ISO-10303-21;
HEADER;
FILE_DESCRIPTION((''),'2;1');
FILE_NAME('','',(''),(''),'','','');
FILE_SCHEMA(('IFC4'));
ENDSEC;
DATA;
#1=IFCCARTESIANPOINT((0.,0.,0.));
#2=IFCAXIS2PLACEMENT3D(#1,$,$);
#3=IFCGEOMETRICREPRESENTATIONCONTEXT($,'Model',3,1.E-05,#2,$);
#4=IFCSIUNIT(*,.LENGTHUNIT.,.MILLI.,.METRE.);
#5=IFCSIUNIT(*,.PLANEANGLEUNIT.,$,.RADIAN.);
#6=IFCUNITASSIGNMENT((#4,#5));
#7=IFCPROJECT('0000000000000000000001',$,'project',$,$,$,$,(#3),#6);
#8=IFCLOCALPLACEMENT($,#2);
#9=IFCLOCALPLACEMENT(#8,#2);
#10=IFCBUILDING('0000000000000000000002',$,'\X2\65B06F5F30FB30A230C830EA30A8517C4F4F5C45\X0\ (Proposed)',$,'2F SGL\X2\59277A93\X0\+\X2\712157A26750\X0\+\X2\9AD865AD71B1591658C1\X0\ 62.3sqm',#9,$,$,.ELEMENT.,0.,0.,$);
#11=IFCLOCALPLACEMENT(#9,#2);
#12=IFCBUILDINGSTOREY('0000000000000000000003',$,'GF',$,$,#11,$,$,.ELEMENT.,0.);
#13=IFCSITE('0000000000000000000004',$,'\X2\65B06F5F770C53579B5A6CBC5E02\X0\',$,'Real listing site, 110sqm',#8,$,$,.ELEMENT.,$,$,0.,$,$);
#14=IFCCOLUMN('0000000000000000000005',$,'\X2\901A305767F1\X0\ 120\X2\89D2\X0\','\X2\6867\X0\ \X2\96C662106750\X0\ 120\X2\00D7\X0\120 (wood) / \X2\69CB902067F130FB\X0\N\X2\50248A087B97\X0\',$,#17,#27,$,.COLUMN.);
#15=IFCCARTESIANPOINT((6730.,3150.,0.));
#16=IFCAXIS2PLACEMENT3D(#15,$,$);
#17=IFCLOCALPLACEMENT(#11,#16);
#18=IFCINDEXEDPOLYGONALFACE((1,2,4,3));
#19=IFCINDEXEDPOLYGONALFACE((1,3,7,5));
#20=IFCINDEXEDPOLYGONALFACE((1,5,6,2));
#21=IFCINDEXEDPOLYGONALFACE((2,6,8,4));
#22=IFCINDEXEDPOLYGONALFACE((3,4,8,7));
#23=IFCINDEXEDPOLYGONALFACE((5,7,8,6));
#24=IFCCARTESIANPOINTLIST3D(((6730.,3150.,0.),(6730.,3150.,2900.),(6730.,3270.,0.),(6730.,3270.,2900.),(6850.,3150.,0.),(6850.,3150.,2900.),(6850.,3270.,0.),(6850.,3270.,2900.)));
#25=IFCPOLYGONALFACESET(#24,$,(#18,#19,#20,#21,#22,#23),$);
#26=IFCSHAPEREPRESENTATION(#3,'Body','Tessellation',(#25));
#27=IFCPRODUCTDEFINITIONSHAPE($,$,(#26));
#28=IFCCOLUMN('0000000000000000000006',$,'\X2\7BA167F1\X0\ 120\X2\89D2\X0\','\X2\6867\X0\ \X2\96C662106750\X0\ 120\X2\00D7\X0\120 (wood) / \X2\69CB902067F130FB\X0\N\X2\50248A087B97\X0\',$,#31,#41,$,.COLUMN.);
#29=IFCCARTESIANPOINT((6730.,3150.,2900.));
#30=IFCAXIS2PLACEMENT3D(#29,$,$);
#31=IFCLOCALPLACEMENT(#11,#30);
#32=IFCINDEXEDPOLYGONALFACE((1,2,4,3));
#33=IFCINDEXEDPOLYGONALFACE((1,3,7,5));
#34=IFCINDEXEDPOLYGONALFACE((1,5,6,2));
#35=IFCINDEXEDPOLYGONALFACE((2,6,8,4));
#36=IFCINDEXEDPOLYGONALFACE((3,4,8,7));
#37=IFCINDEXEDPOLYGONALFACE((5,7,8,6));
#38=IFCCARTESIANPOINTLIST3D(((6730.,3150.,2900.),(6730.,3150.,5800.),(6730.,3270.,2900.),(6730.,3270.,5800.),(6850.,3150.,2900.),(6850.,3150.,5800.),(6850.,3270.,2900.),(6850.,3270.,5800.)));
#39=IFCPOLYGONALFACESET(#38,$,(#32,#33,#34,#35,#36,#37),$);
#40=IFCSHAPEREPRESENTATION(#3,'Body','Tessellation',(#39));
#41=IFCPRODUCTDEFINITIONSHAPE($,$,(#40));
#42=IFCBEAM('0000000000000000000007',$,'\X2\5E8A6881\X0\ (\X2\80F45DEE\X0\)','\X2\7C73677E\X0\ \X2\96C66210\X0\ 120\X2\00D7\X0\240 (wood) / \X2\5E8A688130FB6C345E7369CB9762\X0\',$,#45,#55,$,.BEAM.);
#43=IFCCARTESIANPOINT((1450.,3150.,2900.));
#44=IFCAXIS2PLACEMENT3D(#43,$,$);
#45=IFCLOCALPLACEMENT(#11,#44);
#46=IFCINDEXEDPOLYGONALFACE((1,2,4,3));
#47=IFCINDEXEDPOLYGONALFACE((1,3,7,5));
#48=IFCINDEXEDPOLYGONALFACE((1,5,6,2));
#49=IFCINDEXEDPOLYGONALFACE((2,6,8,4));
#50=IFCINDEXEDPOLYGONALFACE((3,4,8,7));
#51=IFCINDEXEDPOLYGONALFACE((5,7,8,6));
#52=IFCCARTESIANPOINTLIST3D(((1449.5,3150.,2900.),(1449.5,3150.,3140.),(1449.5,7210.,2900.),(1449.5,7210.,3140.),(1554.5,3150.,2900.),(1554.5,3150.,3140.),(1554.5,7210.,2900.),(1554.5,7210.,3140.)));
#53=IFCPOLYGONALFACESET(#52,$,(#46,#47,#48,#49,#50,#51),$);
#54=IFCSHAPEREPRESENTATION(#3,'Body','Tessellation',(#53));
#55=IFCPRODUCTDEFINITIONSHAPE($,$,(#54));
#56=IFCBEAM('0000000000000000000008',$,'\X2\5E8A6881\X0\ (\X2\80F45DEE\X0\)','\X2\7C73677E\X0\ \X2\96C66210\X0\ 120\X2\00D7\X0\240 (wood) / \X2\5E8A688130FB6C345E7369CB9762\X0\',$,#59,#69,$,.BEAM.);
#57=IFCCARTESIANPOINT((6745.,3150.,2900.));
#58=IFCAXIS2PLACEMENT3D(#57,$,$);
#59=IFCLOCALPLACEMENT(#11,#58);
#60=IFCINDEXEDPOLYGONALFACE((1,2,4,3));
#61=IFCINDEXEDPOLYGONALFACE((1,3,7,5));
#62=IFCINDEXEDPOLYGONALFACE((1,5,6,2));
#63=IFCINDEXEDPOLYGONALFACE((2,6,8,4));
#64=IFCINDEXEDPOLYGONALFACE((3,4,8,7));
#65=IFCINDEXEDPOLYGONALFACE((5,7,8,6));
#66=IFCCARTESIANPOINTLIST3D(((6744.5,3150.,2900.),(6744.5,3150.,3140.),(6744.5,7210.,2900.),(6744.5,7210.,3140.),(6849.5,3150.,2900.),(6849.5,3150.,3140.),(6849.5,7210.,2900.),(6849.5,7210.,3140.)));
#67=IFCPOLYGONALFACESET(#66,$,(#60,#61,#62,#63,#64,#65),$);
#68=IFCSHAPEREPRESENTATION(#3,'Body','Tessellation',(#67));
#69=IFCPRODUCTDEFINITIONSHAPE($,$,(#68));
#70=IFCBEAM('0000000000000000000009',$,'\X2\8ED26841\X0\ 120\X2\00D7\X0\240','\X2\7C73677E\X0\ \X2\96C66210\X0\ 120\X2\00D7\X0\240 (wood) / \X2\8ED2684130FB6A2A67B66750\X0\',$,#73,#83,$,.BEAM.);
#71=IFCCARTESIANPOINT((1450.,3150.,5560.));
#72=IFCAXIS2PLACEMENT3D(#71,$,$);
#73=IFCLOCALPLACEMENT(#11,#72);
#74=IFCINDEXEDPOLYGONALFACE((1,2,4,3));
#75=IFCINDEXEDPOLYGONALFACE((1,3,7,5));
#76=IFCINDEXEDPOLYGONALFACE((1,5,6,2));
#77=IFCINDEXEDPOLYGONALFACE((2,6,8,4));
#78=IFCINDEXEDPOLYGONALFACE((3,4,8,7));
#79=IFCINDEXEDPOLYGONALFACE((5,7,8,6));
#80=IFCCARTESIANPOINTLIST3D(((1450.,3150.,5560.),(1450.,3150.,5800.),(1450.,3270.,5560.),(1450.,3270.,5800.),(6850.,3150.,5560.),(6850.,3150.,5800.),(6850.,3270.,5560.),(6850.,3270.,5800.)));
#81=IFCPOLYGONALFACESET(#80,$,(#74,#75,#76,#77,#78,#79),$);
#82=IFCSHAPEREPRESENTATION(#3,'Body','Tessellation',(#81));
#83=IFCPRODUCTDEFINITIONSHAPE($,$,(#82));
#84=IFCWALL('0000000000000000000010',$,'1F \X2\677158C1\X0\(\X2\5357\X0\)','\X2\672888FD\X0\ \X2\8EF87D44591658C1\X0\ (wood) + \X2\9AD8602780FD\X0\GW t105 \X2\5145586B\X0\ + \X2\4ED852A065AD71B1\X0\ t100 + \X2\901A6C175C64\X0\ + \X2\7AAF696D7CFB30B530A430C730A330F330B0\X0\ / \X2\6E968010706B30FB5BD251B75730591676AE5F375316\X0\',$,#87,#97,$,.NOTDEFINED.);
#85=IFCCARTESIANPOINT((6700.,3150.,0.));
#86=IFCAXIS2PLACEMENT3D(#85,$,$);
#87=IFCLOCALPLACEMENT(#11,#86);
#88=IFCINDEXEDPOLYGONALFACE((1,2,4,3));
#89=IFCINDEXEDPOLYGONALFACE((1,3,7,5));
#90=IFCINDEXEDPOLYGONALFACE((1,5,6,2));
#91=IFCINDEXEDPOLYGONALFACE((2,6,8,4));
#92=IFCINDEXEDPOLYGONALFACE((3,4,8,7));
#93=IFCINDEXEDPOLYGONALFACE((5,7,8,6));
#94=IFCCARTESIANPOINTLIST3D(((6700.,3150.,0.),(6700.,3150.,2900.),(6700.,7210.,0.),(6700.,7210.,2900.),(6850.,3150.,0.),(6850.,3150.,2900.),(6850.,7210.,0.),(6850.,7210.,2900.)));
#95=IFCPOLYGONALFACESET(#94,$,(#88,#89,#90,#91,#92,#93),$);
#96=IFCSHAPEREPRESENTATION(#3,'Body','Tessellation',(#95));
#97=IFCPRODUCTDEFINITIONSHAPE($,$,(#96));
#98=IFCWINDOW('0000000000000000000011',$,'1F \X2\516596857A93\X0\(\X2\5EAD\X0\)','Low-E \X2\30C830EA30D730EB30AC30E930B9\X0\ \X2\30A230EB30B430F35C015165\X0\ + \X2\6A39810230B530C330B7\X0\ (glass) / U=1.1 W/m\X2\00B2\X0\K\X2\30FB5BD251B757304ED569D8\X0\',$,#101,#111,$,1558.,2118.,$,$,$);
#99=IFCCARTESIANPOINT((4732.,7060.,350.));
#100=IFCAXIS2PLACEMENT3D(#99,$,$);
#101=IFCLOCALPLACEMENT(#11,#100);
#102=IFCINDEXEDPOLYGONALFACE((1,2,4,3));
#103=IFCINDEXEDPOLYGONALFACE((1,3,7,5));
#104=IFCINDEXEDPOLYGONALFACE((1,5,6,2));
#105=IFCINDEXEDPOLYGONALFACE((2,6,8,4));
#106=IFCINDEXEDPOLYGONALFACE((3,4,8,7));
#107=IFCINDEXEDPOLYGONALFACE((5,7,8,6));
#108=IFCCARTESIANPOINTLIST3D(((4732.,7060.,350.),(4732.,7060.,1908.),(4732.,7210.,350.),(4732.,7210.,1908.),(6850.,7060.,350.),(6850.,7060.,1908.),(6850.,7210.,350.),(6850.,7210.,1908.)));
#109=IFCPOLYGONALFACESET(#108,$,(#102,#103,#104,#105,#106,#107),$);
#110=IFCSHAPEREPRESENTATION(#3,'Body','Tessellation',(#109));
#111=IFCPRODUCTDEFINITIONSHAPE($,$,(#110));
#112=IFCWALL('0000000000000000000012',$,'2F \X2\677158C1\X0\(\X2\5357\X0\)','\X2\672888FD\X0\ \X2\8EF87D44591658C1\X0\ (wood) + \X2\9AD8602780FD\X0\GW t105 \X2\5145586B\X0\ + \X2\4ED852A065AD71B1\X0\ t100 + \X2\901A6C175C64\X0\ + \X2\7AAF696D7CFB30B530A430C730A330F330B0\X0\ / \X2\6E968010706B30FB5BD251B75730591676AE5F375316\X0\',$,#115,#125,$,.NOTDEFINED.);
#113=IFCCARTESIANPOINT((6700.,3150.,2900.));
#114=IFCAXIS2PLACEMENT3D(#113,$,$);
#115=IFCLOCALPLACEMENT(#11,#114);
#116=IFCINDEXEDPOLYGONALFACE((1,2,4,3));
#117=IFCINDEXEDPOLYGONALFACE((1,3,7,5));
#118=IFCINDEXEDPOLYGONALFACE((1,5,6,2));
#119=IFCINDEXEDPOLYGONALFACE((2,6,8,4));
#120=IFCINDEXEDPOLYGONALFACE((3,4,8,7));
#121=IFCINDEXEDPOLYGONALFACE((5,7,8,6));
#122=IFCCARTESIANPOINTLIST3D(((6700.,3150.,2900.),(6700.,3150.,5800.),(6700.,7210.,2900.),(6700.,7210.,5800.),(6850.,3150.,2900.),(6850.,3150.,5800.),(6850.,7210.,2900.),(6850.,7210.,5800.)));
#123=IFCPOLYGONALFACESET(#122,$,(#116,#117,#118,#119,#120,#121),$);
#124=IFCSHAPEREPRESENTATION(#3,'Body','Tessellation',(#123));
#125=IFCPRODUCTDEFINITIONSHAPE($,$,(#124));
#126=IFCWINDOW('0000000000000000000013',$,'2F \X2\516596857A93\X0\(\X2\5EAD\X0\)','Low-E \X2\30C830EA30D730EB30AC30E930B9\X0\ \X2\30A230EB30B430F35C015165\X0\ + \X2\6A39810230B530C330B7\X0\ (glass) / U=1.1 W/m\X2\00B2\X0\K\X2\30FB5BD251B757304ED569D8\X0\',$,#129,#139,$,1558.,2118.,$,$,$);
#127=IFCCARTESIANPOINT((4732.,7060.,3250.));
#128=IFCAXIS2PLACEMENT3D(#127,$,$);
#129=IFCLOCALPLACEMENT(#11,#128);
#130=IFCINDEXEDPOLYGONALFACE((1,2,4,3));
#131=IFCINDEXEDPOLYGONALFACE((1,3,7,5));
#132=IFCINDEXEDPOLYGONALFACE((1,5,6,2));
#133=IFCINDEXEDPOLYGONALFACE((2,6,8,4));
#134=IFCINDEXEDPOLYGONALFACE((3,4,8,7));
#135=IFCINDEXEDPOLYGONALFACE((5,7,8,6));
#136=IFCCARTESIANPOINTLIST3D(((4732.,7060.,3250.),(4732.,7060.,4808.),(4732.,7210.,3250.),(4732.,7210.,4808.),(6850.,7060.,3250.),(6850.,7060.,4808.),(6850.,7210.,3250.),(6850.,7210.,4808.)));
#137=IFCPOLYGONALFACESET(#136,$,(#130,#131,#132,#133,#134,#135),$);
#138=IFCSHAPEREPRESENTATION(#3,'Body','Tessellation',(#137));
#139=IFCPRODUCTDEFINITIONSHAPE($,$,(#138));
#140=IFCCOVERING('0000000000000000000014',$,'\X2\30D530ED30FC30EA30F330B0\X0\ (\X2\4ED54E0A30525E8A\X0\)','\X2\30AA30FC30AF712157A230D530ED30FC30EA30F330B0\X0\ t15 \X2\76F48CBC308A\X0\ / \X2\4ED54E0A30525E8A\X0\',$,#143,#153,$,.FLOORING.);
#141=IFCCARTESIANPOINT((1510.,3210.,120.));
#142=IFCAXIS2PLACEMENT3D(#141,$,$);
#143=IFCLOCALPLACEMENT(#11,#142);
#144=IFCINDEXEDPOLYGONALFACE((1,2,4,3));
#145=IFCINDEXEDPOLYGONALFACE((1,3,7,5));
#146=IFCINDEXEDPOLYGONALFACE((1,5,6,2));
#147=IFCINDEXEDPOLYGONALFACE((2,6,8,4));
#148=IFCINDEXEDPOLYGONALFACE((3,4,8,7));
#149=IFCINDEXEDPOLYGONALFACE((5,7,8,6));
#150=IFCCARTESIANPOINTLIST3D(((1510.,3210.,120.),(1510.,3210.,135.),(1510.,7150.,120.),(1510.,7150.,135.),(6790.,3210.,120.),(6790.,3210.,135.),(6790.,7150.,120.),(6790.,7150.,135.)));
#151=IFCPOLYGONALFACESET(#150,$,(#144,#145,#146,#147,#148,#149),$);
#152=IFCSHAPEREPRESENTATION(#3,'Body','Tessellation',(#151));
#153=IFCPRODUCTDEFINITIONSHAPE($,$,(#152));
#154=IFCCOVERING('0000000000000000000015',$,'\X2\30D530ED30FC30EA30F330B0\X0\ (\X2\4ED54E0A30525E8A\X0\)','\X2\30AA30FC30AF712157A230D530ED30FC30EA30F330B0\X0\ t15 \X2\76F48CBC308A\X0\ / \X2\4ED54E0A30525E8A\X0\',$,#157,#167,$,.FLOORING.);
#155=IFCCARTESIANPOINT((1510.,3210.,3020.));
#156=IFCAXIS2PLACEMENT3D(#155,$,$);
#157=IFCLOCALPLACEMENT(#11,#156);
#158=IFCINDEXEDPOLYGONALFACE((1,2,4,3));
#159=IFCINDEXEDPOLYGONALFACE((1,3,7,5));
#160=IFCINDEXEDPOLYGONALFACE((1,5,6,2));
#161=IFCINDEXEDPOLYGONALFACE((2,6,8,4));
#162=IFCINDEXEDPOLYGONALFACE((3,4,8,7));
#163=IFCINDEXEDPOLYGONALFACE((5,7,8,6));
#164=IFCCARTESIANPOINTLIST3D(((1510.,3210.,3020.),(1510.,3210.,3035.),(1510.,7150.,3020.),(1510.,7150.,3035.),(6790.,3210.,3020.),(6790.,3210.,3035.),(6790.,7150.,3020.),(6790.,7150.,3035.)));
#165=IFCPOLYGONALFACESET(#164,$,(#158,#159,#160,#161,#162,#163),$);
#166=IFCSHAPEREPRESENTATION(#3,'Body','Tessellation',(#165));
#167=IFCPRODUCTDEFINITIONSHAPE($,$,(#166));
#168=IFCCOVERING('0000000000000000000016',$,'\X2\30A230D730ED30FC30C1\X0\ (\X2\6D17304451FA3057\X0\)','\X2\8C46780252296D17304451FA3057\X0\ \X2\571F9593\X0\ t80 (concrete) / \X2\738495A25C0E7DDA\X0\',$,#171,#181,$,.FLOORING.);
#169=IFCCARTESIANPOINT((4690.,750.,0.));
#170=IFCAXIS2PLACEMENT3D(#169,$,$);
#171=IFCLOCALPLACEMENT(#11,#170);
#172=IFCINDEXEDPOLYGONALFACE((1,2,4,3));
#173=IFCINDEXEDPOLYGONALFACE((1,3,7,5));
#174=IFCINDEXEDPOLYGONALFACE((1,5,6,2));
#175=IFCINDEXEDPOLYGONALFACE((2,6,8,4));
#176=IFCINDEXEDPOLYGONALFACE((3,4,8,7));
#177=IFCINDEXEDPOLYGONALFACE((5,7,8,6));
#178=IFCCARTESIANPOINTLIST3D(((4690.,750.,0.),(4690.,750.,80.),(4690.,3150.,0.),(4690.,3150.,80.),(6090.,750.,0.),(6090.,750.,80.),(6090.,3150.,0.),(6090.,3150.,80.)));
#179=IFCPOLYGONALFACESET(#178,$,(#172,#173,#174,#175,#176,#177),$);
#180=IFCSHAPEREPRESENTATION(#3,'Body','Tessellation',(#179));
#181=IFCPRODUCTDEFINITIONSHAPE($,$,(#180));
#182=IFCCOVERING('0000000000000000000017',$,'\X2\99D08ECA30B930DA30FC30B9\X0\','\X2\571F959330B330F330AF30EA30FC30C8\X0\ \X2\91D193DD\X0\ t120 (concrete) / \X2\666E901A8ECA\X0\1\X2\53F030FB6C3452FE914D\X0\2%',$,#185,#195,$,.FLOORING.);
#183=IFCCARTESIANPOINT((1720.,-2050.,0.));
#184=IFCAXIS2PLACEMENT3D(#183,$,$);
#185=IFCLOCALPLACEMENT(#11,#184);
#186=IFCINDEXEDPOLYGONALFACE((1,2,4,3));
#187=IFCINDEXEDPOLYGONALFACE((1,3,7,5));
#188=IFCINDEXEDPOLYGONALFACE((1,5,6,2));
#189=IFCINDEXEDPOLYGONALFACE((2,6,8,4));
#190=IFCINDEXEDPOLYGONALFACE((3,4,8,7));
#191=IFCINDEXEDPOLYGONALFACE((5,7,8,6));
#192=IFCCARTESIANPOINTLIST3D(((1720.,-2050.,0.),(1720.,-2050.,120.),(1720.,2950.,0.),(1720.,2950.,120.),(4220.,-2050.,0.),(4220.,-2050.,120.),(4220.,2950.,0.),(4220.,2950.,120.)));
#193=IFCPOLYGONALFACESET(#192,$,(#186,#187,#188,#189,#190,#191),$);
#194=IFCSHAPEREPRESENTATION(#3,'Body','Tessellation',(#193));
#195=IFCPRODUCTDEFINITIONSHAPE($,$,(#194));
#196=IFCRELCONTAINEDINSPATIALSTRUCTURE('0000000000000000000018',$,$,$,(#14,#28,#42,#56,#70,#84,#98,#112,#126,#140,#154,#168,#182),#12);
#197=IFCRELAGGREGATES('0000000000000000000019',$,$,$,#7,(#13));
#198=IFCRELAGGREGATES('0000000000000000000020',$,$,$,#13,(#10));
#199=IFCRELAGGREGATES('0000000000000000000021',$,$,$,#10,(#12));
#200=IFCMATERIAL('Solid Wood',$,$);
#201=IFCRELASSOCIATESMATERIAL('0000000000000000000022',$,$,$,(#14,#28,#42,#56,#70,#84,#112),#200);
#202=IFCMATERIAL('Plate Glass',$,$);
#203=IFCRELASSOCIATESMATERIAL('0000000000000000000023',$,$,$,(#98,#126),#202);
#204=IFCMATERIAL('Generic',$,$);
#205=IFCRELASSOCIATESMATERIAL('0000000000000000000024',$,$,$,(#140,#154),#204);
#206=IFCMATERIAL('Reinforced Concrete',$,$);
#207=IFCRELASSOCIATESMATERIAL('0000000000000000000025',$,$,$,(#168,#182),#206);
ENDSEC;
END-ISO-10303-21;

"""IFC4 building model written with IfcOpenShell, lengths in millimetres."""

from ifc_helpers import new_model, si_unit, frame, frame_2d, origin, place, context, project, spatial, rectangle, extrude, material, element, fill, save


model = new_model("IFC4")

# Units and contexts
model_context = context("Model", 3, precision=1e-05, world=origin())
ifc_project = project(units=[si_unit("LENGTHUNIT", "METRE", prefix="MILLI"), si_unit("PLANEANGLEUNIT", "RADIAN")], contexts=[model_context])

# Site, building, storey
site_placement = place(None, origin())
site = spatial("IfcSite", under=ifc_project, at=site_placement, Name="新潟県南魚沼市", ObjectType="Real listing site, 110sqm", CompositionType="ELEMENT", RefElevation=0.0)
building_placement = place(site_placement, origin())
building = spatial("IfcBuilding", under=site, at=building_placement, Name="新潟・アトリエ兼住居 (Proposed)", ObjectType="2F SGL大窓+無垢材+高断熱外壁 62.3sqm", CompositionType="ELEMENT", ElevationOfRefHeight=0.0, ElevationOfTerrain=0.0)
storey_placement = place(building_placement, origin())
storey = spatial("IfcBuildingStorey", under=building, at=storey_placement, Name="GF", CompositionType="ELEMENT", Elevation=0.0)

# Columns
ifc_material_1 = material(Name="Solid Wood")
column_1_placement = place(storey_placement, frame((6730.0, 3150.0, 0.0)))
element("IfcColumn", 1, at=column_1_placement, inside=storey, material=ifc_material_1, Name="通し柱 120角", Description="桧 集成材 120×120 (wood) / 構造柱・N値計算", PredefinedType="COLUMN", context=model_context, shape_type="SweptSolid", body=[
    extrude(rectangle(XDim=120.0, YDim=120.0, at=frame_2d((60.0, 60.0))), frame((6730.0, 3150.0, 0.0)), (0.0, 0.0, 1.0), 2900.0),
])
column_2_placement = place(storey_placement, frame((6730.0, 3150.0, 2900.0)))
element("IfcColumn", 2, at=column_2_placement, inside=storey, material=ifc_material_1, Name="管柱 120角", Description="桧 集成材 120×120 (wood) / 構造柱・N値計算", PredefinedType="COLUMN", context=model_context, shape_type="SweptSolid", body=[
    extrude(rectangle(XDim=120.0, YDim=120.0, at=frame_2d((60.0, 60.0))), frame((6730.0, 3150.0, 2900.0)), (0.0, 0.0, 1.0), 2900.0),
])

# Beams
beam_1_placement = place(storey_placement, frame((1450.0, 3150.0, 2900.0)))
element("IfcBeam", 3, at=beam_1_placement, inside=storey, material=ifc_material_1, Name="床梁 (胴差)", Description="米松 集成 120×240 (wood) / 床梁・水平構面", PredefinedType="BEAM", context=model_context, shape_type="SweptSolid", body=[
    extrude(rectangle(XDim=105.0, YDim=4060.0, at=frame_2d((52.0, 2030.0))), frame((1450.0, 3150.0, 2900.0)), (0.0, 0.0, 1.0), 240.0),
])
beam_2_placement = place(storey_placement, frame((6745.0, 3150.0, 2900.0)))
element("IfcBeam", 4, at=beam_2_placement, inside=storey, material=ifc_material_1, Name="床梁 (胴差)", Description="米松 集成 120×240 (wood) / 床梁・水平構面", PredefinedType="BEAM", context=model_context, shape_type="SweptSolid", body=[
    extrude(rectangle(XDim=105.0, YDim=4060.0, at=frame_2d((52.0, 2030.0))), frame((6745.0, 3150.0, 2900.0)), (0.0, 0.0, 1.0), 240.0),
])
beam_3_placement = place(storey_placement, frame((1450.0, 3150.0, 5560.0)))
element("IfcBeam", 5, at=beam_3_placement, inside=storey, material=ifc_material_1, Name="軒桁 120×240", Description="米松 集成 120×240 (wood) / 軒桁・横架材", PredefinedType="BEAM", context=model_context, shape_type="SweptSolid", body=[
    extrude(rectangle(XDim=5400.0, YDim=120.0, at=frame_2d((2700.0, 60.0))), frame((1450.0, 3150.0, 5560.0)), (0.0, 0.0, 1.0), 240.0),
])

# Wall, opening, window
wall_1_placement = place(storey_placement, frame((6700.0, 3150.0, 0.0)))
wall_1 = element("IfcWall", 6, at=wall_1_placement, inside=storey, material=ifc_material_1, Name="1F 東壁(南)", Description="木製 軸組外壁 (wood) + 高性能GW t105 充填 + 付加断熱 t100 + 通気層 + 窯業系サイディング / 準耐火・寒冷地外皮強化", PredefinedType="NOTDEFINED", context=model_context, shape_type="SweptSolid", body=[
    extrude(rectangle(XDim=150.0, YDim=4060.0, at=frame_2d((75.0, 2030.0))), frame((6700.0, 3150.0, 0.0)), (0.0, 0.0, 1.0), 2900.0),
])
opening_1_placement = place(storey_placement, frame((4732.0, 7060.0, 350.0)))
opening_1 = element("IfcOpeningElement", 7, at=opening_1_placement, cuts=wall_1, PredefinedType="NOTDEFINED", context=model_context, shape_type="SweptSolid", body=[
    extrude(rectangle(XDim=2118.0, YDim=150.0, at=frame_2d((1059.0, 75.0))), frame((4732.0, 7060.0, 350.0)), (0.0, 0.0, 1.0), 1558.0),
])
ifc_material_2 = material(Name="Plate Glass")
window_1_placement = place(storey_placement, frame((4732.0, 7060.0, 350.0)))
window_1 = element("IfcWindow", 8, at=window_1_placement, inside=storey, material=ifc_material_2, Name="1F 入隅窓(庭)", Description="Low-E トリプルガラス アルゴン封入 + 樹脂サッシ (glass) / U=1.1 W/m²K・寒冷地仕様", OverallHeight=1558.0, OverallWidth=2118.0, context=model_context, shape_type="SweptSolid", body=[
    extrude(rectangle(XDim=2118.0, YDim=150.0, at=frame_2d((1059.0, 75.0))), frame((4732.0, 7060.0, 350.0)), (0.0, 0.0, 1.0), 1558.0),
])
fill(opening_1, window_1)

# Wall, opening, window
wall_2_placement = place(storey_placement, frame((6700.0, 3150.0, 2900.0)))
wall_2 = element("IfcWall", 9, at=wall_2_placement, inside=storey, material=ifc_material_1, Name="2F 東壁(南)", Description="木製 軸組外壁 (wood) + 高性能GW t105 充填 + 付加断熱 t100 + 通気層 + 窯業系サイディング / 準耐火・寒冷地外皮強化", PredefinedType="NOTDEFINED", context=model_context, shape_type="SweptSolid", body=[
    extrude(rectangle(XDim=150.0, YDim=4060.0, at=frame_2d((75.0, 2030.0))), frame((6700.0, 3150.0, 2900.0)), (0.0, 0.0, 1.0), 2900.0),
])
opening_2_placement = place(storey_placement, frame((4732.0, 7060.0, 3250.0)))
opening_2 = element("IfcOpeningElement", 10, at=opening_2_placement, cuts=wall_2, PredefinedType="NOTDEFINED", context=model_context, shape_type="SweptSolid", body=[
    extrude(rectangle(XDim=2118.0, YDim=150.0, at=frame_2d((1059.0, 75.0))), frame((4732.0, 7060.0, 3250.0)), (0.0, 0.0, 1.0), 1558.0),
])
window_2_placement = place(storey_placement, frame((4732.0, 7060.0, 3250.0)))
window_2 = element("IfcWindow", 11, at=window_2_placement, inside=storey, material=ifc_material_2, Name="2F 入隅窓(庭)", Description="Low-E トリプルガラス アルゴン封入 + 樹脂サッシ (glass) / U=1.1 W/m²K・寒冷地仕様", OverallHeight=1558.0, OverallWidth=2118.0, context=model_context, shape_type="SweptSolid", body=[
    extrude(rectangle(XDim=2118.0, YDim=150.0, at=frame_2d((1059.0, 75.0))), frame((4732.0, 7060.0, 3250.0)), (0.0, 0.0, 1.0), 1558.0),
])
fill(opening_2, window_2)

# Coverings
ifc_material_3 = material(Name="Generic")
covering_1_placement = place(storey_placement, frame((1510.0, 3210.0, 120.0)))
element("IfcCovering", 12, at=covering_1_placement, inside=storey, material=ifc_material_3, Name="フローリング (仕上げ床)", Description="オーク無垢フローリング t15 直貼り / 仕上げ床", PredefinedType="FLOORING", context=model_context, shape_type="SweptSolid", body=[
    extrude(rectangle(XDim=5280.0, YDim=3940.0, at=frame_2d((2640.0, 1970.0))), frame((1510.0, 3210.0, 120.0)), (0.0, 0.0, 1.0), 15.0),
])
covering_2_placement = place(storey_placement, frame((1510.0, 3210.0, 3020.0)))
element("IfcCovering", 13, at=covering_2_placement, inside=storey, material=ifc_material_3, Name="フローリング (仕上げ床)", Description="オーク無垢フローリング t15 直貼り / 仕上げ床", PredefinedType="FLOORING", context=model_context, shape_type="SweptSolid", body=[
    extrude(rectangle(XDim=5280.0, YDim=3940.0, at=frame_2d((2640.0, 1970.0))), frame((1510.0, 3210.0, 3020.0)), (0.0, 0.0, 1.0), 15.0),
])
ifc_material_4 = material(Name="Reinforced Concrete")
covering_3_placement = place(storey_placement, frame((4690.0, 750.0, 0.0)))
element("IfcCovering", 14, at=covering_3_placement, inside=storey, material=ifc_material_4, Name="アプローチ (洗い出し)", Description="豆砂利洗い出し 土間 t80 (concrete) / 玄関導線", PredefinedType="FLOORING", context=model_context, shape_type="SweptSolid", body=[
    extrude(rectangle(XDim=1400.0, YDim=2400.0, at=frame_2d((700.0, 1200.0))), frame((4690.0, 750.0, 0.0)), (0.0, 0.0, 1.0), 80.0),
])
covering_4_placement = place(storey_placement, frame((1720.0, -2050.0, 0.0)))
element("IfcCovering", 15, at=covering_4_placement, inside=storey, material=ifc_material_4, Name="駐車スペース", Description="土間コンクリート 金鏝 t120 (concrete) / 普通車1台・水勾配2%", PredefinedType="FLOORING", context=model_context, shape_type="SweptSolid", body=[
    extrude(rectangle(XDim=2500.0, YDim=5000.0, at=frame_2d((1250.0, 2500.0))), frame((1720.0, -2050.0, 0.0)), (0.0, 0.0, 1.0), 120.0),
])

save(model, "model.ifc")
